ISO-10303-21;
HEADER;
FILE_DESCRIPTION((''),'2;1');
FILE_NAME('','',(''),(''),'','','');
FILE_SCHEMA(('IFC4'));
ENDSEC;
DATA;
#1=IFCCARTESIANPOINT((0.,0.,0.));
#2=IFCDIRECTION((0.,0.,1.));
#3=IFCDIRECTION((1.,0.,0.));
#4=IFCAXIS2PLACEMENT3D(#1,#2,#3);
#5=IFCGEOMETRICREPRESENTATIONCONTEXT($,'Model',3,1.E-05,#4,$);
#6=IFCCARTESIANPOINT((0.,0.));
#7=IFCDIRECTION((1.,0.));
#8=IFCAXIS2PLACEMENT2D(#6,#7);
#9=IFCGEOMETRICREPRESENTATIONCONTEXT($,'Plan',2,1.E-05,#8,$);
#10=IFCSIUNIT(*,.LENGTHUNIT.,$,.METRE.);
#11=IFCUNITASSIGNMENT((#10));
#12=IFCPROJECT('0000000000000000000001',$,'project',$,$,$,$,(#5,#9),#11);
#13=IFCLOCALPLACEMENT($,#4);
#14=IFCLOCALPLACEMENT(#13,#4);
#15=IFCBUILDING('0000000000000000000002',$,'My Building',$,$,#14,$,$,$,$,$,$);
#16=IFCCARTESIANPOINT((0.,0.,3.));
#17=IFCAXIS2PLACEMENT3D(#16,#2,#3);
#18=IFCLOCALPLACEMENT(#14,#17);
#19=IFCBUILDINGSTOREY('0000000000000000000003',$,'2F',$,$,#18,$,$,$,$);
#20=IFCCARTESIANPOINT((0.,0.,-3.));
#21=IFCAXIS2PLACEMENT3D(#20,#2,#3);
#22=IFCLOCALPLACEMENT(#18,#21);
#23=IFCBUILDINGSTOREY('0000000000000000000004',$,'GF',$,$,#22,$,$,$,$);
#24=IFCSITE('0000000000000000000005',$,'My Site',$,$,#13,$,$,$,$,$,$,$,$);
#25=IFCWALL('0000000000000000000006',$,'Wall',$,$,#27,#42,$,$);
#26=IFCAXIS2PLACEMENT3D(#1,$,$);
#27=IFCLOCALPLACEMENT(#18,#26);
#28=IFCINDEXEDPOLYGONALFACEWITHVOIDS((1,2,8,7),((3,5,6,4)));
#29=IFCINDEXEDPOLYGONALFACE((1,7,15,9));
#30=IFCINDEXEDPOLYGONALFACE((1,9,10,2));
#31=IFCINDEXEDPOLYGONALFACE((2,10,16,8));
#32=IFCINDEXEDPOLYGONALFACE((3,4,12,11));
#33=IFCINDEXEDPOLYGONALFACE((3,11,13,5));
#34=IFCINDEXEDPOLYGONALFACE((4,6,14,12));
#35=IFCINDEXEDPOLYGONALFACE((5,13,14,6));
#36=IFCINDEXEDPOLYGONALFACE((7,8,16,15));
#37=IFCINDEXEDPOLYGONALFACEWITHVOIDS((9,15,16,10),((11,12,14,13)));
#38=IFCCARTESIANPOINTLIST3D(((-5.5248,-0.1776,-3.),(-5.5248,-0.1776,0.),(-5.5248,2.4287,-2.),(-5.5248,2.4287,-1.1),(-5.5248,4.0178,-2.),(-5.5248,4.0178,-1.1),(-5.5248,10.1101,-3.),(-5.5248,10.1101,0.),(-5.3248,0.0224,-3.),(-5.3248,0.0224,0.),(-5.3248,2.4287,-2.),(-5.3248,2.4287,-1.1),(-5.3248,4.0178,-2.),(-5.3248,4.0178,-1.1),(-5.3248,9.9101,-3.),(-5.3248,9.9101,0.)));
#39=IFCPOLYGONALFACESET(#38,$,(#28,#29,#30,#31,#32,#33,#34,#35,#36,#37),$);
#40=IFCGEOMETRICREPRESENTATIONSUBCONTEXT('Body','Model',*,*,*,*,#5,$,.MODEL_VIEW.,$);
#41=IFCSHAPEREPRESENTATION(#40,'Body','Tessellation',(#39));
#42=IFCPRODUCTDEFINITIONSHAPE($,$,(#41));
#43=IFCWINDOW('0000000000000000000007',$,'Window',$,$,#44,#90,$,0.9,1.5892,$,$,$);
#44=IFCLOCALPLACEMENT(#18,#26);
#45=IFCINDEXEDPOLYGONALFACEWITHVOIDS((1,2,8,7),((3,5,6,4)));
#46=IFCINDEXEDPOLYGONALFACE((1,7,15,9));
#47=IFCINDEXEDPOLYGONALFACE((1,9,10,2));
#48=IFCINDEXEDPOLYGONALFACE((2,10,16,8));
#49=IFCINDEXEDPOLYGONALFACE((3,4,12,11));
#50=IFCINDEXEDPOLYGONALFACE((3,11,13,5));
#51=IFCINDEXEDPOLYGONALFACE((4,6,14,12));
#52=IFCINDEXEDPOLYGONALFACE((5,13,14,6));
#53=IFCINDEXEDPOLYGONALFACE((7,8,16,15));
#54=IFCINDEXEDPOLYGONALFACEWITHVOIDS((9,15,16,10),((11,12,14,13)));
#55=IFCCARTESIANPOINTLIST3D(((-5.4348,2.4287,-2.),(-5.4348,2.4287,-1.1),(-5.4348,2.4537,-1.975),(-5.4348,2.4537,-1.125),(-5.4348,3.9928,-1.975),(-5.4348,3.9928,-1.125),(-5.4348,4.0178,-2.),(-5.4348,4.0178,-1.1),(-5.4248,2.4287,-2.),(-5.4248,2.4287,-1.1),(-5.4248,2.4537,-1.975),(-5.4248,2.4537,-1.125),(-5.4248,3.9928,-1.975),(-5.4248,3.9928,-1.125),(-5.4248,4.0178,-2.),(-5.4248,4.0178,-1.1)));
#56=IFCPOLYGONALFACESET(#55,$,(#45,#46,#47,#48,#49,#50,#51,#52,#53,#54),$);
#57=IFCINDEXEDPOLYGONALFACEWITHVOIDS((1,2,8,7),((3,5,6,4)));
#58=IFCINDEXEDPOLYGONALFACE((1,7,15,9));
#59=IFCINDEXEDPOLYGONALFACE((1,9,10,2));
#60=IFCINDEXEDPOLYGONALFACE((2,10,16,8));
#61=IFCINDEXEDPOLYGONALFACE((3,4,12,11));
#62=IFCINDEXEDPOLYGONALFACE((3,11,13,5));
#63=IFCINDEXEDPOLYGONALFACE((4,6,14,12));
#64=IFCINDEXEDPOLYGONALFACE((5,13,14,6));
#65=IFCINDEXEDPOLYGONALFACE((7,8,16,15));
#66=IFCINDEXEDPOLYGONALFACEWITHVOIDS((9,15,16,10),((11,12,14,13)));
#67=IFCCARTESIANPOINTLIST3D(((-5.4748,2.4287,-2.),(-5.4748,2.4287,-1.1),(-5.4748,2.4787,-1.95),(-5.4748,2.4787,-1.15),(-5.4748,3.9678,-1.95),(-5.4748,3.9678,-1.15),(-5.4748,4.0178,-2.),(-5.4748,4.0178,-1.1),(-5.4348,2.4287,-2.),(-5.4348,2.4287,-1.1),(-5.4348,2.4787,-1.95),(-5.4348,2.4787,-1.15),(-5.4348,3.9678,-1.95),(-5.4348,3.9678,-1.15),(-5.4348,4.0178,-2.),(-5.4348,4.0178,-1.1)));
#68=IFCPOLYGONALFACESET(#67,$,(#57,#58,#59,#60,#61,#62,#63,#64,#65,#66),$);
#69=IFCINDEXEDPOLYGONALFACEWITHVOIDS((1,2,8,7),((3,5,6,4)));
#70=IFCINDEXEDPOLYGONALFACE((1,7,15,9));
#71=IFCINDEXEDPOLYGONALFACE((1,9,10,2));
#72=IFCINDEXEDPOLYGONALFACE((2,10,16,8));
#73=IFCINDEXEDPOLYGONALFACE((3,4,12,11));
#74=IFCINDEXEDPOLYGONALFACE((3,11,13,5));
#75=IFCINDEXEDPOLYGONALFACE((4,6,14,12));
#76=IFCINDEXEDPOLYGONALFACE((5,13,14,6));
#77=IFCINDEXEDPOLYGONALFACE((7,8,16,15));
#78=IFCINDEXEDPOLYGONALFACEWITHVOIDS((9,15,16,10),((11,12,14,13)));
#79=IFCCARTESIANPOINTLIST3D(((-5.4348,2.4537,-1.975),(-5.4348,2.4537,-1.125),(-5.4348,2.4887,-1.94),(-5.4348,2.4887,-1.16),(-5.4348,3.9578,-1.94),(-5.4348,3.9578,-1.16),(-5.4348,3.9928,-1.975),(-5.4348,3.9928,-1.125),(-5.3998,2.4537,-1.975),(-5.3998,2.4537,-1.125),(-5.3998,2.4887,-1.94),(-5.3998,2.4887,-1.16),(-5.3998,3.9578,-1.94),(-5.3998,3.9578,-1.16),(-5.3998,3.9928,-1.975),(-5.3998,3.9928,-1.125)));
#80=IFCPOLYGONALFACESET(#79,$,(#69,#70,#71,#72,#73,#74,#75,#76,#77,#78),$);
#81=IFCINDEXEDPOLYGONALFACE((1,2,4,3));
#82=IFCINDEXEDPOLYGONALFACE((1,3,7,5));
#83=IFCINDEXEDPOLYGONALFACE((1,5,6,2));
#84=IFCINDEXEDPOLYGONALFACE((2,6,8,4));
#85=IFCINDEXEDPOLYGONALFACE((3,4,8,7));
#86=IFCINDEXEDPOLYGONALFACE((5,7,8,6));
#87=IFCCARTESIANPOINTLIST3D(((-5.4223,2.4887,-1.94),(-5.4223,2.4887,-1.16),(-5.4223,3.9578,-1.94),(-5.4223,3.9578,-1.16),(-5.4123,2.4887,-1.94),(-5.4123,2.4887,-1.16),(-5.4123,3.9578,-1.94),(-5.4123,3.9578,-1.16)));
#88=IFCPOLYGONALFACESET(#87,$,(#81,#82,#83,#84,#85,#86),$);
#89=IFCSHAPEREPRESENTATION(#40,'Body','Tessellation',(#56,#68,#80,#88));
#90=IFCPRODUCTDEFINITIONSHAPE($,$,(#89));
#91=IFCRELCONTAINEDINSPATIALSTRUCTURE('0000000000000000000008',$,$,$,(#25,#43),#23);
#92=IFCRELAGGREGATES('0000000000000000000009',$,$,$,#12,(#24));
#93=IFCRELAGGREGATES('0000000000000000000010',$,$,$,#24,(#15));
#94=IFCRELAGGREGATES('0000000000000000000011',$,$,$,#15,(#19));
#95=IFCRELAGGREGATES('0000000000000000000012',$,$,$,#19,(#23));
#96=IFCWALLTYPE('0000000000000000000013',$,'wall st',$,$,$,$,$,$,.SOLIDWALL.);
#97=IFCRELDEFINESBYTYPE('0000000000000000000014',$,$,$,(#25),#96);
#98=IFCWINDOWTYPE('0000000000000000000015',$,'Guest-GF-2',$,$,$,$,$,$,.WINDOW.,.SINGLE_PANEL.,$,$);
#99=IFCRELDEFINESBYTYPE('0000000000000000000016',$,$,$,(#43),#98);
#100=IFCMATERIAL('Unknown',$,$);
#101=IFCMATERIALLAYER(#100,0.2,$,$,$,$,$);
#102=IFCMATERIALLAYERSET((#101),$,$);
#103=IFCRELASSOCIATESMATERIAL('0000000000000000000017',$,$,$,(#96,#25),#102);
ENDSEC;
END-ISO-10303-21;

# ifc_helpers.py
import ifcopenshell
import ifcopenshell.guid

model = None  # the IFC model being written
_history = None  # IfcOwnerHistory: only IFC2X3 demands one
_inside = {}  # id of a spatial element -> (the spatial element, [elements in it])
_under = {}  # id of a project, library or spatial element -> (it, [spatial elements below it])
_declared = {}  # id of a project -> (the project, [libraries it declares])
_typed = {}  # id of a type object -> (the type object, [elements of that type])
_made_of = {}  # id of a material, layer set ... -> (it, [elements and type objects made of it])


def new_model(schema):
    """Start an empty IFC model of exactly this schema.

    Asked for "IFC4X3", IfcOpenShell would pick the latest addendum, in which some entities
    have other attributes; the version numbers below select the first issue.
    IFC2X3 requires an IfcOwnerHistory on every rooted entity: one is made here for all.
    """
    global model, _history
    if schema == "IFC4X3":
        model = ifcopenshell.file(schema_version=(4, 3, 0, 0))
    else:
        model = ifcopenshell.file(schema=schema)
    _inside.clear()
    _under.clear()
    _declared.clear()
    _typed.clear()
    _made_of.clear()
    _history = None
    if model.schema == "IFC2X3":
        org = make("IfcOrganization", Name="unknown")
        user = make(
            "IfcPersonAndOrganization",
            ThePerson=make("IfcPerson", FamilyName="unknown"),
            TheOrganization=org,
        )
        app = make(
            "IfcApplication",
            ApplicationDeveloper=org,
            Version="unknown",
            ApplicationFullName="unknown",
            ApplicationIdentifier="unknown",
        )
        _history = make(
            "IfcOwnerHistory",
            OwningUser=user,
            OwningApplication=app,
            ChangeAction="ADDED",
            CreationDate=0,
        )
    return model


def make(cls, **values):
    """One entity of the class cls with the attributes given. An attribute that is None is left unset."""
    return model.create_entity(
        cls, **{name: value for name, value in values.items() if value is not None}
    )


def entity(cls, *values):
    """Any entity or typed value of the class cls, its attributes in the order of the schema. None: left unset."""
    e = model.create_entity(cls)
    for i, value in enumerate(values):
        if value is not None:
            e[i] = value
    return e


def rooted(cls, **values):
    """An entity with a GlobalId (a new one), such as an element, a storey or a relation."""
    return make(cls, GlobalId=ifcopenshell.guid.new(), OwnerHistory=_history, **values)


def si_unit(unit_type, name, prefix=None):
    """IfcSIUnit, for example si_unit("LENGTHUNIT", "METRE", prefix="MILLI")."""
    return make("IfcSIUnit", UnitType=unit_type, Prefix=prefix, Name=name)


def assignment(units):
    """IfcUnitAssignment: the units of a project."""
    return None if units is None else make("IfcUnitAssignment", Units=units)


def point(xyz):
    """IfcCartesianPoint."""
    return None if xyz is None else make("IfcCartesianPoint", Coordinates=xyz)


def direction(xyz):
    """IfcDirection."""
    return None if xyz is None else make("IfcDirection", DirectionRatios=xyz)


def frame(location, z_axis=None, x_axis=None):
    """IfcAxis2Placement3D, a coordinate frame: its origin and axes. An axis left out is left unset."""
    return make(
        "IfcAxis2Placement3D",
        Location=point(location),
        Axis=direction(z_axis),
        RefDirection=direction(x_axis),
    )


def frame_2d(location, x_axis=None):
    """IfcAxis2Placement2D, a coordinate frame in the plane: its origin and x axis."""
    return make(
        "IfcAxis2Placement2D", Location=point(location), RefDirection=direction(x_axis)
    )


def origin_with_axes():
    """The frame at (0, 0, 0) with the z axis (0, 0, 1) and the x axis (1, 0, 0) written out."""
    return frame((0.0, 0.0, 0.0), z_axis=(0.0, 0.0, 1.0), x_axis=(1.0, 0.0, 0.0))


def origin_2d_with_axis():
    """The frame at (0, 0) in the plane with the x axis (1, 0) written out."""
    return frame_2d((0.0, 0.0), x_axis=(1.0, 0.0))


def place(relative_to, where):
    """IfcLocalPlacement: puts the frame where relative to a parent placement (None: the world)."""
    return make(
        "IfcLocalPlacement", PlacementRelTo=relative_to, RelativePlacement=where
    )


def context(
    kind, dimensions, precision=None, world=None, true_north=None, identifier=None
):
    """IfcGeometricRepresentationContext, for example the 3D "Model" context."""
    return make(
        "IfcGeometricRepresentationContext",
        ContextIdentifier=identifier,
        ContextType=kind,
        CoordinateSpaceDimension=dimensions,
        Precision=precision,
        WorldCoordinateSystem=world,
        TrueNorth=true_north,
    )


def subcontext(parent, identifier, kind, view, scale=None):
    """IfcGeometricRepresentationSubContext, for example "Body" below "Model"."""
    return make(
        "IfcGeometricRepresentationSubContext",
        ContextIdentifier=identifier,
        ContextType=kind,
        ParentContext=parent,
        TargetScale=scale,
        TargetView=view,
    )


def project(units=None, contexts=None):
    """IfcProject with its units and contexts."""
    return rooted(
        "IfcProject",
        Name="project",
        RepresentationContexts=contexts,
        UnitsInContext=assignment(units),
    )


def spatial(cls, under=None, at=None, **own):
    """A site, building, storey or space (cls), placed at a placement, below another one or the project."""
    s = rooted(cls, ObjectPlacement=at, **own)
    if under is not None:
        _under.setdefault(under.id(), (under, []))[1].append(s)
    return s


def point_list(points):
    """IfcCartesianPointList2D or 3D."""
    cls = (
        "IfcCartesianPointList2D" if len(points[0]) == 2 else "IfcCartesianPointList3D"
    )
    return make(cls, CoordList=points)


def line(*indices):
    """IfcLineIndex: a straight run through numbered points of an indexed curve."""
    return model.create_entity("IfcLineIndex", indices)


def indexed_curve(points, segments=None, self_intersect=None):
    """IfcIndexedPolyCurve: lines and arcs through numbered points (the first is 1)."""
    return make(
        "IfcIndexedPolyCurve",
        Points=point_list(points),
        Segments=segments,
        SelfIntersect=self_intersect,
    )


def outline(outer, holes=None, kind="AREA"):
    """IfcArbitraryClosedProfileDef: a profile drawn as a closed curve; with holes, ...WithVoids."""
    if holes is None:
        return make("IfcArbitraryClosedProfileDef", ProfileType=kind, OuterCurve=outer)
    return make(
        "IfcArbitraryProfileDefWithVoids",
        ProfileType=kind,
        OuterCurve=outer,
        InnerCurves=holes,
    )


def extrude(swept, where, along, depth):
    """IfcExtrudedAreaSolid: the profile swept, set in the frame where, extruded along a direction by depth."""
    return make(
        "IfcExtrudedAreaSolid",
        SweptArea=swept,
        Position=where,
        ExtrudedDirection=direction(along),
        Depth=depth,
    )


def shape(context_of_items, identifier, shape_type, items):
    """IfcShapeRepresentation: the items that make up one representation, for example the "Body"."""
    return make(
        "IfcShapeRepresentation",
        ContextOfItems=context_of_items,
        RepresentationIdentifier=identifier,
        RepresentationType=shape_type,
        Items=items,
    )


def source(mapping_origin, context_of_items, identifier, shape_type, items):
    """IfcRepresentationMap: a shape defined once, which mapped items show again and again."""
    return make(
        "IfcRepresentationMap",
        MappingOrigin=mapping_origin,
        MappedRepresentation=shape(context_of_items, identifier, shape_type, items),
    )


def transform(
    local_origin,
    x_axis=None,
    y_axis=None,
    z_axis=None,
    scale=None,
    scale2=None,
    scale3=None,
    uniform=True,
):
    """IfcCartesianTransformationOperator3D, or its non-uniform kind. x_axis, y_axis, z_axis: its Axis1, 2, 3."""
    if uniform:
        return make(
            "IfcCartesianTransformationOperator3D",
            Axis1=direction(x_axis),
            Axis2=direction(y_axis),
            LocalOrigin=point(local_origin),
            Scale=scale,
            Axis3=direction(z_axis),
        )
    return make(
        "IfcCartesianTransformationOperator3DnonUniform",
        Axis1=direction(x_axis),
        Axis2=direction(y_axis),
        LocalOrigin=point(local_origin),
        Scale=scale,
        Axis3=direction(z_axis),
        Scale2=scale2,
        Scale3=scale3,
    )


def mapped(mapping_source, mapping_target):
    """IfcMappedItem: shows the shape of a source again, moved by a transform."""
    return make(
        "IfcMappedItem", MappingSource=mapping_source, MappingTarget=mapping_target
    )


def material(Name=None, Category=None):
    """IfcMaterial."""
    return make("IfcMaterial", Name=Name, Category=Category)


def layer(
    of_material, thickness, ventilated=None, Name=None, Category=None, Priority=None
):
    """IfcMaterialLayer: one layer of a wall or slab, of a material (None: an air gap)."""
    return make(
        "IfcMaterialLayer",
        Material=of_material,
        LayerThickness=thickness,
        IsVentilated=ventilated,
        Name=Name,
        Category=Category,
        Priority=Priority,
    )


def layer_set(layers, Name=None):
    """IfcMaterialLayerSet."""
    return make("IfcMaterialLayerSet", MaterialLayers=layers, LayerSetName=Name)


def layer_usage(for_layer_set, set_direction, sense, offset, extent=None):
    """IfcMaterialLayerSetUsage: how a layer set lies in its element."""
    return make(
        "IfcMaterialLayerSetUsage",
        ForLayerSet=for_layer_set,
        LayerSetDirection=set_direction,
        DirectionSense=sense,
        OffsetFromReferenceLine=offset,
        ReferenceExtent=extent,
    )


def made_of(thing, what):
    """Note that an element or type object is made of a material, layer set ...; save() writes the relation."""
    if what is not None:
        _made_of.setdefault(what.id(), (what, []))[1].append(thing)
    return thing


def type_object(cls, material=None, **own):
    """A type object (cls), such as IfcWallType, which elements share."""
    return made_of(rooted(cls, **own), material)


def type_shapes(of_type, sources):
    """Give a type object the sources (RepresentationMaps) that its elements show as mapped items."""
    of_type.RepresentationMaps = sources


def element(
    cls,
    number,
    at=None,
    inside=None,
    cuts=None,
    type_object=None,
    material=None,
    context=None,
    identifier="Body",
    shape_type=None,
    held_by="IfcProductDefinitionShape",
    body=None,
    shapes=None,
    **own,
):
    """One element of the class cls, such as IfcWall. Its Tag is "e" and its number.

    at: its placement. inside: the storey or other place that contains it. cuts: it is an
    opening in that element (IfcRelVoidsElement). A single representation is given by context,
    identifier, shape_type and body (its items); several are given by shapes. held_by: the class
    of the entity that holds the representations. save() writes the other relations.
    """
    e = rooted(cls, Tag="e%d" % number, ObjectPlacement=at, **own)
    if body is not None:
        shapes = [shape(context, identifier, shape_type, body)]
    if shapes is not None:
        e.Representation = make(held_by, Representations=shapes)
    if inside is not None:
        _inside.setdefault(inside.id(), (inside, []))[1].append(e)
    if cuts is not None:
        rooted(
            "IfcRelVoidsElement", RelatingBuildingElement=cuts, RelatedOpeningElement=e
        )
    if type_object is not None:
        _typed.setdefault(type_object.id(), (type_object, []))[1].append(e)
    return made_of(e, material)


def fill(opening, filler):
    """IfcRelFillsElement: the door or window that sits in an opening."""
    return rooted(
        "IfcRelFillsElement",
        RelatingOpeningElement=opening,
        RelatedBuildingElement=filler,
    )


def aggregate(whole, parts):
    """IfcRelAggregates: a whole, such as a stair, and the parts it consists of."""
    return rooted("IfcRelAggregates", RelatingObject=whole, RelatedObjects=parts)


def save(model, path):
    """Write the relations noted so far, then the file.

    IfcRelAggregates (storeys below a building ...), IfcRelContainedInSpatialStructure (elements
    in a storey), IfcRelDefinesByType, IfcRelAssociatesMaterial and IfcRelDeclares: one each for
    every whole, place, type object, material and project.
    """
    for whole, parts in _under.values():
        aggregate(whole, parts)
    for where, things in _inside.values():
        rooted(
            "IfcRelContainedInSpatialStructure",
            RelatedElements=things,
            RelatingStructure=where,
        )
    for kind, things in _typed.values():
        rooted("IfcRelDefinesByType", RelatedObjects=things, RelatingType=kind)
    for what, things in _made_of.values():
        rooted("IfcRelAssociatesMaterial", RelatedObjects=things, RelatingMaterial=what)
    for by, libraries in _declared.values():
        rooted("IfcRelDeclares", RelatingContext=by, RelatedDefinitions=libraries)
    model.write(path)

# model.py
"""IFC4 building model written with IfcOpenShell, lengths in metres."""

from ifc_helpers import new_model, entity, si_unit, frame, origin_with_axes, origin_2d_with_axis, place, context, subcontext, project, spatial, line, indexed_curve, outline, extrude, shape, source, transform, mapped, material, layer, layer_set, layer_usage, type_object, type_shapes, element, fill, save


model = new_model("IFC4")

# Units and contexts
model_context = context("Model", 3, precision=1e-05, world=origin_with_axes())
plan_context = context("Plan", 2, precision=1e-05, world=origin_2d_with_axis())
body_context_1 = subcontext(model_context, "Body", "Model", "MODEL_VIEW")
body_context_2 = subcontext(plan_context, "Body", "Plan", "PLAN_VIEW")
ifc_project = project(units=[si_unit("LENGTHUNIT", "METRE")], contexts=[model_context, plan_context])

# Site, building, storeys
site_placement = place(None, origin_with_axes())
site = spatial("IfcSite", under=ifc_project, at=site_placement, Name="My Site")
building_placement = place(site_placement, origin_with_axes())
building = spatial("IfcBuilding", under=site, at=building_placement, Name="My Building")
storey_1_placement = place(building_placement, frame((0.0, 0.0, 3.0), z_axis=(0.0, 0.0, 1.0), x_axis=(1.0, 0.0, 0.0)))
storey_1 = spatial("IfcBuildingStorey", under=building, at=storey_1_placement, Name="2F")
storey_2_placement = place(storey_1_placement, frame((0.0, 0.0, -3.0), z_axis=(0.0, 0.0, 1.0), x_axis=(1.0, 0.0, 0.0)))
storey_2 = spatial("IfcBuildingStorey", under=storey_1, at=storey_2_placement, Name="GF")

# Shared definitions
ifc_material = material(Name="Unknown")

# Shared definitions
ifc_layer_1 = layer(ifc_material, 0.2)
ifc_layer_set_1 = layer_set([ifc_layer_1])
wall_type = type_object("IfcWallType", Name="wall st", PredefinedType="SOLIDWALL", material=ifc_layer_set_1)

# Wall, opening, window
ifc_layer_usage_1 = layer_usage(ifc_layer_set_1, "AXIS2", "POSITIVE", 0.0)
wall_1_placement = place(storey_2_placement, frame((-5.5248, 10.1101, 0.0), z_axis=(0.0, 0.0, 1.0), x_axis=(0.0, -1.0, 0.0)))
wall_1 = element("IfcWall", 1, at=wall_1_placement, inside=storey_2, type_object=wall_type, material=ifc_layer_usage_1, Name="Wall", context=body_context_1, shape_type="SweptSolid", body=[
    extrude(outline(indexed_curve([(0.0, 0.0), (0.2, 0.2), (10.0877, 0.2), (10.2877, 0.0)], segments=[line(1, 2, 3, 4, 1)])), origin_with_axes(), (0.0, 0.0, 1.0), 3.0),
])
shared_shape_1 = source(origin_with_axes(), body_context_1, "Body", "SweptSolid", [
    extrude(outline(indexed_curve([(0.0, 0.0), (1.5892, 0.0), (1.5892, 0.9), (0.0, 0.9)], segments=[line(1, 2, 3, 4, 1)])), frame((0.0, -0.6, 0.0), z_axis=(0.0, -1.0, 0.0), x_axis=(1.0, 0.0, 0.0)), (0.0, 0.0, -1.0), 1.2),
])
opening_1_placement = place(wall_1_placement, frame((6.0922, 0.0, 1.0), z_axis=(0.0, 0.0, 1.0), x_axis=(1.0, 0.0, 0.0)))
opening_1 = element("IfcOpeningElement", 2, at=opening_1_placement, cuts=wall_1, PredefinedType="OPENING", context=body_context_1, shape_type="MappedRepresentation", body=[
    mapped(shared_shape_1, transform((0.0, 0.0, 0.0), x_axis=(1.0, 0.0, 0.0), y_axis=(0.0, 1.0, 0.0), z_axis=(0.0, 0.0, 1.0), scale=1.0)),
])
window_type_1 = type_object("IfcWindowType", Name="Guest-GF-2", PartitioningType="SINGLE_PANEL", PredefinedType="WINDOW")
shared_shape_2 = source(origin_with_axes(), body_context_1, "Body", "SweptSolid", [
    extrude(outline(indexed_curve([(0.0, 0.0), (1.5892, 0.0), (1.5892, 0.9), (0.0, 0.9)], segments=[line(1, 2, 3, 4, 1)]), holes=[indexed_curve([(0.025, 0.025), (1.5642, 0.025), (1.5642, 0.875), (0.025, 0.875)], segments=[line(1, 2, 3, 4, 1)])]), frame((0.0, 0.09, 0.0), z_axis=(0.0, -1.0, 0.0), x_axis=(1.0, 0.0, 0.0)), (0.0, 0.0, -1.0), 0.01),
    extrude(outline(indexed_curve([(0.0, 0.0), (1.5892, 0.0), (1.5892, 0.9), (0.0, 0.9)], segments=[line(1, 2, 3, 4, 1)]), holes=[indexed_curve([(0.05, 0.05), (1.5392, 0.05), (1.5392, 0.85), (0.05, 0.85)], segments=[line(1, 2, 3, 4, 1)])]), frame((0.0, 0.05, 0.0), z_axis=(0.0, -1.0, 0.0), x_axis=(1.0, 0.0, 0.0)), (0.0, 0.0, -1.0), 0.04),
    extrude(outline(indexed_curve([(0.0, 0.0), (1.5392, 0.0), (1.5392, 0.85), (0.0, 0.85)], segments=[line(1, 2, 3, 4, 1)]), holes=[indexed_curve([(0.035, 0.035), (1.5042, 0.035), (1.5042, 0.815), (0.035, 0.815)], segments=[line(1, 2, 3, 4, 1)])]), frame((0.025, 0.09, 0.025), z_axis=(0.0, -1.0, 0.0), x_axis=(1.0, 0.0, 0.0)), (0.0, 0.0, -1.0), 0.035),
    extrude(outline(indexed_curve([(0.035, 0.035), (1.5042, 0.035), (1.5042, 0.815), (0.035, 0.815)], segments=[line(1, 2, 3, 4, 1)])), frame((0.025, 0.1025, 0.025), z_axis=(0.0, -1.0, 0.0), x_axis=(1.0, 0.0, 0.0)), (0.0, 0.0, -1.0), 0.01),
])
shared_shape_3 = source(origin_with_axes(), body_context_2, "Body", "Curve2D", [
    entity("IfcIndexedPolyCurve", entity("IfcCartesianPointList2D", [[0.05, 0.05], [1.5392, 0.05]])),
    entity("IfcIndexedPolyCurve", entity("IfcCartesianPointList2D", [[0.0, 0.1], [0.025, 0.1], [0.025, 0.09], [0.05, 0.09], [0.05, 0.05], [0.0, 0.05]]), [entity("IfcLineIndex", [1, 2, 3, 4, 5, 6, 1])]),
    entity("IfcIndexedPolyCurve", entity("IfcCartesianPointList2D", [[1.5892, 0.1], [1.5642, 0.1], [1.5642, 0.09], [1.5392, 0.09], [1.5392, 0.05], [1.5892, 0.05]]), [entity("IfcLineIndex", [1, 2, 3, 4, 5, 6, 1])]),
    entity("IfcIndexedPolyCurve", entity("IfcCartesianPointList2D", [[0.025, 0.09], [0.06, 0.09], [0.06, 0.125], [0.025, 0.125]]), [entity("IfcLineIndex", [1, 2, 3, 4, 1])]),
    entity("IfcIndexedPolyCurve", entity("IfcCartesianPointList2D", [[1.5642, 0.09], [1.5292, 0.09], [1.5292, 0.125], [1.5642, 0.125]]), [entity("IfcLineIndex", [1, 2, 3, 4, 1])]),
    entity("IfcIndexedPolyCurve", entity("IfcCartesianPointList2D", [[0.06, 0.09], [1.5292, 0.09]])),
    entity("IfcIndexedPolyCurve", entity("IfcCartesianPointList2D", [[0.06, 0.125], [1.5292, 0.125]])),
    entity("IfcIndexedPolyCurve", entity("IfcCartesianPointList2D", [[0.06, 0.1075], [1.5292, 0.1075]])),
])
type_shapes(window_type_1, [shared_shape_2, shared_shape_3])
window_1_placement = place(opening_1_placement, frame((0.0, 0.0, 0.0), z_axis=(0.0, 0.0, 1.0), x_axis=(1.0, 0.0, 0.0)))
window_1 = element("IfcWindow", 3, at=window_1_placement, inside=storey_2, type_object=window_type_1, Name="Window", OverallHeight=0.9, OverallWidth=1.5892, shapes=[
    shape(body_context_1, "Body", "MappedRepresentation", [mapped(shared_shape_2, transform((0.0, 0.0, 0.0), x_axis=(1.0, 0.0, 0.0), y_axis=(0.0, 1.0, 0.0), z_axis=(0.0, 0.0, 1.0), scale=1.0))]),
    shape(body_context_2, "Body", "MappedRepresentation", [mapped(shared_shape_3, transform((0.0, 0.0, 0.0), x_axis=(1.0, 0.0, 0.0), y_axis=(0.0, 1.0, 0.0), z_axis=(0.0, 0.0, 1.0), scale=1.0))]),
])
fill(opening_1, window_1)

save(model, "model.ifc")
